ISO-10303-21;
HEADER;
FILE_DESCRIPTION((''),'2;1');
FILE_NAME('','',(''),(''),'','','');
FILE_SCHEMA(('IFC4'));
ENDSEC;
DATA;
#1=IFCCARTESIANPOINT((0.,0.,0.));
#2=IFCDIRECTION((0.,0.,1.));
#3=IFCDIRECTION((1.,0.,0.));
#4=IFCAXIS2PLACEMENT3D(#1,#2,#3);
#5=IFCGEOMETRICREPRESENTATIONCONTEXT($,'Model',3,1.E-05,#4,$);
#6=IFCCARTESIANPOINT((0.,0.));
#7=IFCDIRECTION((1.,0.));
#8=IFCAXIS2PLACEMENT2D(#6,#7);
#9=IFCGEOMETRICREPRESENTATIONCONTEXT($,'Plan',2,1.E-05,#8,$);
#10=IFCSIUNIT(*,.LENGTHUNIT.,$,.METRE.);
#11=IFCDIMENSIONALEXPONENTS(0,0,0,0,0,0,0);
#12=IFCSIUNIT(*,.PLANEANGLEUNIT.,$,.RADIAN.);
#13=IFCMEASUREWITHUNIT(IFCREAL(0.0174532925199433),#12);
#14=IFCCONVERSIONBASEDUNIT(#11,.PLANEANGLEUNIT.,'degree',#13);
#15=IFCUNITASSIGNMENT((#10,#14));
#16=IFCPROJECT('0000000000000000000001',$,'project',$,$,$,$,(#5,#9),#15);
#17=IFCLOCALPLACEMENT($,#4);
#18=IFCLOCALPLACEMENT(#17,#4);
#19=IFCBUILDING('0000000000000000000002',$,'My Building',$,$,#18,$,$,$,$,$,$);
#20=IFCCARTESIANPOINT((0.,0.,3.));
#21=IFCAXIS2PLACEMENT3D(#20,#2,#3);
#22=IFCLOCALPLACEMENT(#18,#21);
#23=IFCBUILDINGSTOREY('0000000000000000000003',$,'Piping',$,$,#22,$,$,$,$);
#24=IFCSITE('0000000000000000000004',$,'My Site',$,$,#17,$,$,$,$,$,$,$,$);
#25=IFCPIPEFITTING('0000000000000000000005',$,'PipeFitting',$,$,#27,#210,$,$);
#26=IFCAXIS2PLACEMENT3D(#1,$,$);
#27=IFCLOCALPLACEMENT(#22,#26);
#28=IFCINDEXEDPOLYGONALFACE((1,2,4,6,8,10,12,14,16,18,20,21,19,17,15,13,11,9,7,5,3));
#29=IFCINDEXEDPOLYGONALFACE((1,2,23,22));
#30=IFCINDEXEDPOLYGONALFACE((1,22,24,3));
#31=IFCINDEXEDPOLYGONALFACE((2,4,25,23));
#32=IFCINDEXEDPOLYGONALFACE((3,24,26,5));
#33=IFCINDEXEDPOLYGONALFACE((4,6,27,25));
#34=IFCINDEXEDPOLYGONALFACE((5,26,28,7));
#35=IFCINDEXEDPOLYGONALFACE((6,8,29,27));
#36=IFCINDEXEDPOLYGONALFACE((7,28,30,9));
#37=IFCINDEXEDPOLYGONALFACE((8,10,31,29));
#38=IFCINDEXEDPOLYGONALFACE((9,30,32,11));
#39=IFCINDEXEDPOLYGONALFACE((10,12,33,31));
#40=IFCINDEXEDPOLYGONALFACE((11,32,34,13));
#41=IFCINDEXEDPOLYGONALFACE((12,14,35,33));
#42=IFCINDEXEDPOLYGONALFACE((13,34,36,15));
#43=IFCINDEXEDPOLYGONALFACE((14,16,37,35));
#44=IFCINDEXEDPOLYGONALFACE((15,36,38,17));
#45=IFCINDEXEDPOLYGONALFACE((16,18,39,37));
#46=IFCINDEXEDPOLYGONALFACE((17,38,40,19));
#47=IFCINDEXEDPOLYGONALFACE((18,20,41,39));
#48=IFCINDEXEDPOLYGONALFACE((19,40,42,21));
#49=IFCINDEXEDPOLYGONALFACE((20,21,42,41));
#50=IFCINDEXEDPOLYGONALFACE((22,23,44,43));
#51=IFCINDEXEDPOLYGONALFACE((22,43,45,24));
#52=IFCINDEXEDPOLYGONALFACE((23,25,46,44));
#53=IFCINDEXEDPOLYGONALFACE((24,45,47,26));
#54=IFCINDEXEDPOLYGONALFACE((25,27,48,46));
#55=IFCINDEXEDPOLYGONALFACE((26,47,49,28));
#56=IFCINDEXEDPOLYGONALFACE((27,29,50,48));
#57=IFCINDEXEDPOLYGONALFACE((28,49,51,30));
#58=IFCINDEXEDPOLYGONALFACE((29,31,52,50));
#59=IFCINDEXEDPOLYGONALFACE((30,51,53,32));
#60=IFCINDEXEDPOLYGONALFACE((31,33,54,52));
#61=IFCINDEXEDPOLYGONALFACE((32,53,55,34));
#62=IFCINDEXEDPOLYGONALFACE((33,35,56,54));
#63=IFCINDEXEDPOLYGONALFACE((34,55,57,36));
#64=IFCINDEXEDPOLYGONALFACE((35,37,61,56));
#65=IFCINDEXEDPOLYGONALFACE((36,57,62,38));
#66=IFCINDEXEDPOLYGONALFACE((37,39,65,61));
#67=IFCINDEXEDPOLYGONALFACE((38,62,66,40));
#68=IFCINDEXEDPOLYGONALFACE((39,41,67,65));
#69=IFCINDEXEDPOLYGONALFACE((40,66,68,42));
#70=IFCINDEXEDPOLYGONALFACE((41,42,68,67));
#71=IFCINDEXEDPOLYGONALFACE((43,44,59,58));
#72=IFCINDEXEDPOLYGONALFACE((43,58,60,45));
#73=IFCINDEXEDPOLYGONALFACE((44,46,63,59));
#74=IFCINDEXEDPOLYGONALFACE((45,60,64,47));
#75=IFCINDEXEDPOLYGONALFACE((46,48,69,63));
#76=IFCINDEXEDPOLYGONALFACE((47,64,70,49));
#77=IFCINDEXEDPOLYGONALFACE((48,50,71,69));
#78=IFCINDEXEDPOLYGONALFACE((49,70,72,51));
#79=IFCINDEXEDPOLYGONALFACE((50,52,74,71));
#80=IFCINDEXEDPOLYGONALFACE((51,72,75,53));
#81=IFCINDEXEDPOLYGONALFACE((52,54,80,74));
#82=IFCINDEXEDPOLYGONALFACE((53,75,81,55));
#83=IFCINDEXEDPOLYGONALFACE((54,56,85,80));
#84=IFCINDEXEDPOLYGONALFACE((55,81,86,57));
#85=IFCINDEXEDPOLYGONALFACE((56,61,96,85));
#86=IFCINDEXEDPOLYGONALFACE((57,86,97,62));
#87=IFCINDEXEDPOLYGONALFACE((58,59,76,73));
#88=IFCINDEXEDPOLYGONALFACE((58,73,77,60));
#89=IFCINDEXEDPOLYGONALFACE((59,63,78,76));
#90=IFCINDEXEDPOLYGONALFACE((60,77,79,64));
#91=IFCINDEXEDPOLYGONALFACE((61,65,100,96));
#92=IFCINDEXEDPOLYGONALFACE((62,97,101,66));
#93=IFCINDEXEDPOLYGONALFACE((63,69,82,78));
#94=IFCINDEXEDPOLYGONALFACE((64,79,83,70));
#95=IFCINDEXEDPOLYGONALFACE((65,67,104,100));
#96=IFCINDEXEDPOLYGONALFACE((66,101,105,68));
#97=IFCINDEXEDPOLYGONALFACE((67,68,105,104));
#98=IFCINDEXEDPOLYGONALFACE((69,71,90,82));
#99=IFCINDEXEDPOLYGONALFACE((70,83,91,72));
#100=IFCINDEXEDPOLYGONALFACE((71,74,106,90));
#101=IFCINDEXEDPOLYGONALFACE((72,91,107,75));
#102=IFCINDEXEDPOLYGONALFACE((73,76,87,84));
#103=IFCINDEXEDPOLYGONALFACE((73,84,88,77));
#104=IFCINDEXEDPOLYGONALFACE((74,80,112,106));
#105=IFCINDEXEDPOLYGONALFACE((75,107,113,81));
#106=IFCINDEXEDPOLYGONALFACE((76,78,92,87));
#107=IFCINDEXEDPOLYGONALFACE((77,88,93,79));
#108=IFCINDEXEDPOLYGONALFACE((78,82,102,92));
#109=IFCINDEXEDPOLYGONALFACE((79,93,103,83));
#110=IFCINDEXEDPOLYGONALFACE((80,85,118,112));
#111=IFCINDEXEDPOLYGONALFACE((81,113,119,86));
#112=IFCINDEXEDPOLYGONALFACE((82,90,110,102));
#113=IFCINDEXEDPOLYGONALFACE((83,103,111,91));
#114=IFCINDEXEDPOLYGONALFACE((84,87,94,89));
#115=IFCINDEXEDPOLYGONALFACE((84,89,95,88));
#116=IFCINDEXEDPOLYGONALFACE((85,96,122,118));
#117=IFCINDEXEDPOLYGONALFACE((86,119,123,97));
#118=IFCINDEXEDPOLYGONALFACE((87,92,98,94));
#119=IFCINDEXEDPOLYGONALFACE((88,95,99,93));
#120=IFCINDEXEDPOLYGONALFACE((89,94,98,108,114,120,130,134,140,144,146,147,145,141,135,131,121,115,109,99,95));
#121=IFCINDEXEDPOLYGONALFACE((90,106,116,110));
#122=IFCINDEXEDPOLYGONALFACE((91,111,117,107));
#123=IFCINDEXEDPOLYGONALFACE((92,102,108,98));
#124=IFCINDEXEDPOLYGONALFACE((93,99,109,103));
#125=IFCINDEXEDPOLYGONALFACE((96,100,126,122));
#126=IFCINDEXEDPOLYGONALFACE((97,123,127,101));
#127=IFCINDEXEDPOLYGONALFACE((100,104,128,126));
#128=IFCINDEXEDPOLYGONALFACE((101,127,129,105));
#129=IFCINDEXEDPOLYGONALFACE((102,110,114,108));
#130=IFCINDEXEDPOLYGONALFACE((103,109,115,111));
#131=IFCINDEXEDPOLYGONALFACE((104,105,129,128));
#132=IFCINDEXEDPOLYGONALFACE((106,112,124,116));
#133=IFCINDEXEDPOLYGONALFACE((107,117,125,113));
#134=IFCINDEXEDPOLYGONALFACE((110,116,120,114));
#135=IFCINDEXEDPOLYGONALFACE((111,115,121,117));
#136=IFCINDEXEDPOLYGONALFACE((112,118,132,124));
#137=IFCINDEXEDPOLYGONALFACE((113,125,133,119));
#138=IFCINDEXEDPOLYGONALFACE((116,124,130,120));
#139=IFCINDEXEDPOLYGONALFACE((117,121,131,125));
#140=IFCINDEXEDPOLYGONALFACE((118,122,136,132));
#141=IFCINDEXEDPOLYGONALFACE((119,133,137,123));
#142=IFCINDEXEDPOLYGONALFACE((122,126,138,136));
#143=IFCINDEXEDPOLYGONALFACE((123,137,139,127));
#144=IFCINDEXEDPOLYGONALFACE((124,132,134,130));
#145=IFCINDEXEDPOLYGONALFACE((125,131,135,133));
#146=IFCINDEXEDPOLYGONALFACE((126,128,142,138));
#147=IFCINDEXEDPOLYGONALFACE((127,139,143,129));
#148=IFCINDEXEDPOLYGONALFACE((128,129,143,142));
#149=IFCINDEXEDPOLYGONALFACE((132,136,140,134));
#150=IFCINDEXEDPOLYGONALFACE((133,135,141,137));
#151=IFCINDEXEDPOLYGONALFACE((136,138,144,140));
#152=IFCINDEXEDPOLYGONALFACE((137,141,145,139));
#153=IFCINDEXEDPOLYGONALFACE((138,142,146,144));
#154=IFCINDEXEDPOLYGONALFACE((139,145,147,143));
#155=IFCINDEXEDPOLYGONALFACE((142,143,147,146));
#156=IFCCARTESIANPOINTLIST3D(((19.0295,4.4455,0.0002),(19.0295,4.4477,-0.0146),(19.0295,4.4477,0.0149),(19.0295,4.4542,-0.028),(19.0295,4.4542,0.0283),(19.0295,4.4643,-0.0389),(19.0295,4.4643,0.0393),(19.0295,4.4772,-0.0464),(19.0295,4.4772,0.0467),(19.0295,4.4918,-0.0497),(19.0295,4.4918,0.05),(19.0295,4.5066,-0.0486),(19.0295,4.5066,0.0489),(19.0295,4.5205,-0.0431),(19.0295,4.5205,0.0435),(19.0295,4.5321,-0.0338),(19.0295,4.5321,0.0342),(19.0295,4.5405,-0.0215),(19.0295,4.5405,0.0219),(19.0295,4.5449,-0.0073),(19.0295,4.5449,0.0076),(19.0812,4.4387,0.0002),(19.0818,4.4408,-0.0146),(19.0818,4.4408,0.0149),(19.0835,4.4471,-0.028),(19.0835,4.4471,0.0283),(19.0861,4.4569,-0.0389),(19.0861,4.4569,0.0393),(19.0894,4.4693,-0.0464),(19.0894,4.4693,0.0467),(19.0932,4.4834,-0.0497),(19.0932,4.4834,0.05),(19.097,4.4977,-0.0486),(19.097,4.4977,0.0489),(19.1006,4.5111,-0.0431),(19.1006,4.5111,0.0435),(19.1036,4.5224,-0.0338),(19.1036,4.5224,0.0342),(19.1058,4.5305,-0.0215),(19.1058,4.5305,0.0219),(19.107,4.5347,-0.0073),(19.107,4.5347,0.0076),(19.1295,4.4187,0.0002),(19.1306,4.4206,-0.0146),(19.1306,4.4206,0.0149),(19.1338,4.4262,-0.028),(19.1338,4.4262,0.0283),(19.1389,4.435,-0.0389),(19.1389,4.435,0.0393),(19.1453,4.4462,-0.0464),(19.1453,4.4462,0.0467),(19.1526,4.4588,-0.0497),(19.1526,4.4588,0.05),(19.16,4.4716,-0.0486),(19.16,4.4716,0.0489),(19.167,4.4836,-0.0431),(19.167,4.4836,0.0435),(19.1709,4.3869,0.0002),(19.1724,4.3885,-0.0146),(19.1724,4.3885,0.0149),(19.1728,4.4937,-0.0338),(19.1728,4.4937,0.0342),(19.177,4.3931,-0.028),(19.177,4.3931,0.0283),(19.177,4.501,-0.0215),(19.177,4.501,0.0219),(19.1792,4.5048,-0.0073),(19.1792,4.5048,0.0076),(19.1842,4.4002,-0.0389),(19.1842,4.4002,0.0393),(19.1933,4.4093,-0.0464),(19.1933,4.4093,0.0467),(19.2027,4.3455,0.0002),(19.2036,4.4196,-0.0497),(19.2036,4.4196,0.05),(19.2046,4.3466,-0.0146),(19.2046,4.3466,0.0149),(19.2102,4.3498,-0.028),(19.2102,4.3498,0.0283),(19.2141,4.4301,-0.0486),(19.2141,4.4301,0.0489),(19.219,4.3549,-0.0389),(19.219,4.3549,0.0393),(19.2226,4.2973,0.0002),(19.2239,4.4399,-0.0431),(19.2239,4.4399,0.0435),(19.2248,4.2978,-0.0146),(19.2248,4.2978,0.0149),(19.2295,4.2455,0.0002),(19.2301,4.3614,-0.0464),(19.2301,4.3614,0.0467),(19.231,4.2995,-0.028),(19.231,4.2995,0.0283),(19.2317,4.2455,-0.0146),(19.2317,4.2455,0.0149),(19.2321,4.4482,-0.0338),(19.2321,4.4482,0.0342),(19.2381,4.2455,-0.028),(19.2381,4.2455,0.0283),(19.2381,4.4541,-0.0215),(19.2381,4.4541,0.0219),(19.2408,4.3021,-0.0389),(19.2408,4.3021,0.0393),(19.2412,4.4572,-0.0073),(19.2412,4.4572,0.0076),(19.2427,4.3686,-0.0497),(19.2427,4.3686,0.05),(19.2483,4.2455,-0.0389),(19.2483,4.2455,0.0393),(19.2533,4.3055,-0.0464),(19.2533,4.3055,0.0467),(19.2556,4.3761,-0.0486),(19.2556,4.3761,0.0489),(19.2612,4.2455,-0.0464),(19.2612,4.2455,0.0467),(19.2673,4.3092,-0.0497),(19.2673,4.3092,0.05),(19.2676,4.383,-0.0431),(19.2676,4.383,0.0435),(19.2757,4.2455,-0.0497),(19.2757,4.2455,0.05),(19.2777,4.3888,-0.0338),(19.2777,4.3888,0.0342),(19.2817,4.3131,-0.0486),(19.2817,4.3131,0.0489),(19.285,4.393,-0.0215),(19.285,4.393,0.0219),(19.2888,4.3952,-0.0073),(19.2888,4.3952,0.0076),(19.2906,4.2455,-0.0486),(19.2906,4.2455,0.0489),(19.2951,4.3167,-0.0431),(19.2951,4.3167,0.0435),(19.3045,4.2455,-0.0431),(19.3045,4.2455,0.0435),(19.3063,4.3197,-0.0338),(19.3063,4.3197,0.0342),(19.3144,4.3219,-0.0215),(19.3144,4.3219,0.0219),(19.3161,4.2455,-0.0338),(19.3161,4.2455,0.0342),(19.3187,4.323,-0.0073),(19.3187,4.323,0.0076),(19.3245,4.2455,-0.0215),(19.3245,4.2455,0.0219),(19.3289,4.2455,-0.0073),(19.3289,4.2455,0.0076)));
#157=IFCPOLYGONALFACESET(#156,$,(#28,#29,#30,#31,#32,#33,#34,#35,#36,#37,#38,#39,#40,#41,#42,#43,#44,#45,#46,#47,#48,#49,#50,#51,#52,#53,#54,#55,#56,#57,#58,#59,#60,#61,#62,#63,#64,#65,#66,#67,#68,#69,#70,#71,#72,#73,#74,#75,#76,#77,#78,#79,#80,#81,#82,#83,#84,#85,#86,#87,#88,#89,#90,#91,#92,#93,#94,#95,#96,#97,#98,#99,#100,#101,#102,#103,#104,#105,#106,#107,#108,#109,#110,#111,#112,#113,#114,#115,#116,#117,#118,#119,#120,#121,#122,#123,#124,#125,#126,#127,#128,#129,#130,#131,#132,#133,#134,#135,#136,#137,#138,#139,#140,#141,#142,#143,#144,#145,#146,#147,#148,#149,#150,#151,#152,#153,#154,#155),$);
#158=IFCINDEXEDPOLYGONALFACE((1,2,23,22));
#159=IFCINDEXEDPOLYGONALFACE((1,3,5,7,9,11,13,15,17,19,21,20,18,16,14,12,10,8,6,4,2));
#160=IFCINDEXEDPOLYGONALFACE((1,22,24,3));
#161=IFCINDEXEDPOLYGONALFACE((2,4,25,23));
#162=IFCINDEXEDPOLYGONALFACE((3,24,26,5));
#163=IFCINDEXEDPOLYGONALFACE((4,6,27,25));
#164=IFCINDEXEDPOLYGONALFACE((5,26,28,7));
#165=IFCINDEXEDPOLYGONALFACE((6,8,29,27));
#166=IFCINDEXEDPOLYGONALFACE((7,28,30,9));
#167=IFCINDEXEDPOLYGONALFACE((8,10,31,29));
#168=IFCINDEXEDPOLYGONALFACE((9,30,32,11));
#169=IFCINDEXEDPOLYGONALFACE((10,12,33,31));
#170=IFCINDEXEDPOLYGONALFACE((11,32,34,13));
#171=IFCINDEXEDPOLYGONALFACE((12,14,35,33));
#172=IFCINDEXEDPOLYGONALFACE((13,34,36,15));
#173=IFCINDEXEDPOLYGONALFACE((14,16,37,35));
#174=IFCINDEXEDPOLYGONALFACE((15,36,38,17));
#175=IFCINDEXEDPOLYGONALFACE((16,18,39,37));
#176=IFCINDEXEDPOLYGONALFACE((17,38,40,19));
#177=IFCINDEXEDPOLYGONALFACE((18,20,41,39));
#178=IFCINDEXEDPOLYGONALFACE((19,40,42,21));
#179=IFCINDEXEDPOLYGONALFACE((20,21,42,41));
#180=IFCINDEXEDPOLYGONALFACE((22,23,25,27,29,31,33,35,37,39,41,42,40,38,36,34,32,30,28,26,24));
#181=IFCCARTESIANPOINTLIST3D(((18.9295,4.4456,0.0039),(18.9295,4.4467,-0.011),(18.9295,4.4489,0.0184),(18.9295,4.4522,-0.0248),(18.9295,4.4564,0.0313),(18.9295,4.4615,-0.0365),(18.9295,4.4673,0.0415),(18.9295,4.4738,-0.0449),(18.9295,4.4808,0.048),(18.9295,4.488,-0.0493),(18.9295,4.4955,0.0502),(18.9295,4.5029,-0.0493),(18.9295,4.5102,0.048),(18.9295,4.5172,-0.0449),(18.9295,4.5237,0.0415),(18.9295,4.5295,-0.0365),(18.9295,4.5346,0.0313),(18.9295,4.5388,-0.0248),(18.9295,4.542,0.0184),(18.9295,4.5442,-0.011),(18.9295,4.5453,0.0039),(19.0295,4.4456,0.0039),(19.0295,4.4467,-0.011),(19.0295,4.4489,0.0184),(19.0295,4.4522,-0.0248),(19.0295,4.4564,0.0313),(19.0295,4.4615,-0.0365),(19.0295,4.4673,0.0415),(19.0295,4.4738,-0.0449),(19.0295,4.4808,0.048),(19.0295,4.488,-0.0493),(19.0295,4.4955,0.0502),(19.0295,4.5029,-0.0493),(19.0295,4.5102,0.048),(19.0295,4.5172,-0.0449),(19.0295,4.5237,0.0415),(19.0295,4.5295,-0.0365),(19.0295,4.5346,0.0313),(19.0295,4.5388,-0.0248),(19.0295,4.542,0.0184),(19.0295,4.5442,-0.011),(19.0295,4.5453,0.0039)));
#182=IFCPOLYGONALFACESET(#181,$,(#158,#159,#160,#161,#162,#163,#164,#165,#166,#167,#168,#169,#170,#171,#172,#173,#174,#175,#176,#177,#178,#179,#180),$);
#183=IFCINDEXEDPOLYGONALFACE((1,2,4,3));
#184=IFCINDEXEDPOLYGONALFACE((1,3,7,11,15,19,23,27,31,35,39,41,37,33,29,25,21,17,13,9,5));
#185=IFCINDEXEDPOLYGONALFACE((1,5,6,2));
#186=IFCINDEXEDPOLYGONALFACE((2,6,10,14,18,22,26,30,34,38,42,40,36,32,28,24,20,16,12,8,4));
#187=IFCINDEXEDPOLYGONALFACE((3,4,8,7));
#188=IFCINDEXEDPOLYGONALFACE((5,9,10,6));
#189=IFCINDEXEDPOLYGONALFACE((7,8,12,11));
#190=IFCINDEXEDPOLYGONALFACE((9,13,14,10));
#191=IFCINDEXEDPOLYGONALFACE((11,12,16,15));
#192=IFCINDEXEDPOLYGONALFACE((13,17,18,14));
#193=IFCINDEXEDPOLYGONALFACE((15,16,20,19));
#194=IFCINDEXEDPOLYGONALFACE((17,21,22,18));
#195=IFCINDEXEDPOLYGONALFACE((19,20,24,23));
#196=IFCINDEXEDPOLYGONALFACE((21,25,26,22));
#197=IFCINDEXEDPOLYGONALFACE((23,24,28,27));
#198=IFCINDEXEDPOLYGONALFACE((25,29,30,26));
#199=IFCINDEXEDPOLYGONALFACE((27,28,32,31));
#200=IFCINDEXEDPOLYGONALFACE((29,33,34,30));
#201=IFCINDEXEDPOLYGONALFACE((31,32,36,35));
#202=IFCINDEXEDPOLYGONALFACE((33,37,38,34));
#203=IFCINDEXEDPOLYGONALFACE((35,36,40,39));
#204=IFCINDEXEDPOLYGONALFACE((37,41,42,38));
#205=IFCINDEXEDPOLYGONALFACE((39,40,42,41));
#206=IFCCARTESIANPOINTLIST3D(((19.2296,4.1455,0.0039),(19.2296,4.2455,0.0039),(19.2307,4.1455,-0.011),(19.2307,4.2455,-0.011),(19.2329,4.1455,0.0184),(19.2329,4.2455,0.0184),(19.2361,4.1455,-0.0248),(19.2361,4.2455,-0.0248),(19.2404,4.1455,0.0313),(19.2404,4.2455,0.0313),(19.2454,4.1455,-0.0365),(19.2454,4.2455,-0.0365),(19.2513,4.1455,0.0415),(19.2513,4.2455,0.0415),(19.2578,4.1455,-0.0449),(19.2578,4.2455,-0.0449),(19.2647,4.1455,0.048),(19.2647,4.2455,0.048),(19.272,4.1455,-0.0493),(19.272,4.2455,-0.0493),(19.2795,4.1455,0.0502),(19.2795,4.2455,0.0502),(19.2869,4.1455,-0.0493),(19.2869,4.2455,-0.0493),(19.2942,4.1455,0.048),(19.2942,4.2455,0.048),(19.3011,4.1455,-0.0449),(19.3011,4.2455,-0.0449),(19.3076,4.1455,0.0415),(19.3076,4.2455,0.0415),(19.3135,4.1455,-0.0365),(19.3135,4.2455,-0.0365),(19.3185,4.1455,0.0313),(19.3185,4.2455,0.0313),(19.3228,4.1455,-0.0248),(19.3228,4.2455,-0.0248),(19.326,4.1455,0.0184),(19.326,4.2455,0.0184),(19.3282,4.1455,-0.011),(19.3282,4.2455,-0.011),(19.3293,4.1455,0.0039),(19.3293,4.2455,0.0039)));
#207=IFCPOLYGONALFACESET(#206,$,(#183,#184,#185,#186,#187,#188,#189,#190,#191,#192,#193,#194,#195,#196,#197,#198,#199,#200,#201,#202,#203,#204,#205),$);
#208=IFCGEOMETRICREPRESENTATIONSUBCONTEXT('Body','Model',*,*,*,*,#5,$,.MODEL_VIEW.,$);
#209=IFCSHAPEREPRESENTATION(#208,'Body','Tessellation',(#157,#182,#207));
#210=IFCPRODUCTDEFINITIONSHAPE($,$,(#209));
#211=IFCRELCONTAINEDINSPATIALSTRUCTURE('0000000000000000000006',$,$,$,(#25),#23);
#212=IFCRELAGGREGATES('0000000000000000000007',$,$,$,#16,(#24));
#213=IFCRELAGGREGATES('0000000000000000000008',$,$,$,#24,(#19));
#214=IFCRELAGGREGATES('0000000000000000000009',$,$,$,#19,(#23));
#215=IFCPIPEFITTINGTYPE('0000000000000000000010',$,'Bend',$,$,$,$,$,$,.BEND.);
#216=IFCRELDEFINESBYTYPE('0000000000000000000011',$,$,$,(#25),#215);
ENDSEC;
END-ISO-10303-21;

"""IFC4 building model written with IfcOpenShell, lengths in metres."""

from ifc_helpers import new_model, entity, si_unit, converted_unit, frame, origin_with_axes, origin_2d_with_axis, place, context, subcontext, project, spatial, circle, extrude, source, transform, mapped, type_object, type_shapes, element, save


model = new_model("IFC4")

# Units and contexts
model_context = context("Model", 3, precision=1e-05, world=origin_with_axes())
plan_context = context("Plan", 2, precision=1e-05, world=origin_2d_with_axis())
body_context = subcontext(model_context, "Body", "Model", "MODEL_VIEW")
ifc_project = project(units=[si_unit("LENGTHUNIT", "METRE"), converted_unit("PLANEANGLEUNIT", "degree", entity("IfcReal", 0.0174532925199433), si_unit("PLANEANGLEUNIT", "RADIAN"), dimensions=[0, 0, 0, 0, 0, 0, 0])], contexts=[model_context, plan_context])

# Site, building, storey
site_placement = place(None, origin_with_axes())
site = spatial("IfcSite", under=ifc_project, at=site_placement, Name="My Site")
building_placement = place(site_placement, origin_with_axes())
building = spatial("IfcBuilding", under=site, at=building_placement, Name="My Building")
storey_placement = place(building_placement, frame((0.0, 0.0, 3.0), z_axis=(0.0, 0.0, 1.0), x_axis=(1.0, 0.0, 0.0)))
storey = spatial("IfcBuildingStorey", under=building, at=storey_placement, Name="Piping")

# Pipe fitting
pipe_fitting_type = type_object("IfcPipeFittingType", Name="Bend", PredefinedType="BEND")
shared_shape = source(origin_with_axes(), body_context, "Body", "SolidModel", [
    entity("IfcSweptDiskSolid", entity("IfcIndexedPolyCurve", entity("IfcCartesianPointList3D", [[0.0, 0.0, -0.1], [0.0, -0.0732, -0.2768], [0.0, -0.25, -0.35]]), [entity("IfcArcIndex", [1, 2, 3])]), 0.05),
    extrude(circle(Radius=0.05), origin_with_axes(), (0.0, 0.0, -1.0), 0.1),
    extrude(circle(Radius=0.05), frame((0.0, -0.25, -0.35), z_axis=(0.0, -1.0, 0.0), x_axis=(1.0, 0.0, 0.0)), (0.0, 0.0, 1.0), 0.1),
])
type_shapes(pipe_fitting_type, [shared_shape])
for number, where, z_axis, x_axis, name in (
    (1, (18.9295, 4.4955, 0.0002), (-1.0, 0.0, 0.0), (0.0, 0.0, 1.0), "PipeFitting"),
):
    element("IfcPipeFitting", number, at=place(storey_placement, frame(where, z_axis=z_axis, x_axis=x_axis)), inside=storey, type_object=pipe_fitting_type, Name=name, context=body_context, shape_type="MappedRepresentation", body=[
        mapped(shared_shape, transform((0.0, 0.0, 0.0), x_axis=(1.0, 0.0, 0.0), y_axis=(0.0, 1.0, 0.0), z_axis=(0.0, 0.0, 1.0), scale=1.0)),
    ])

save(model, "model.ifc")
